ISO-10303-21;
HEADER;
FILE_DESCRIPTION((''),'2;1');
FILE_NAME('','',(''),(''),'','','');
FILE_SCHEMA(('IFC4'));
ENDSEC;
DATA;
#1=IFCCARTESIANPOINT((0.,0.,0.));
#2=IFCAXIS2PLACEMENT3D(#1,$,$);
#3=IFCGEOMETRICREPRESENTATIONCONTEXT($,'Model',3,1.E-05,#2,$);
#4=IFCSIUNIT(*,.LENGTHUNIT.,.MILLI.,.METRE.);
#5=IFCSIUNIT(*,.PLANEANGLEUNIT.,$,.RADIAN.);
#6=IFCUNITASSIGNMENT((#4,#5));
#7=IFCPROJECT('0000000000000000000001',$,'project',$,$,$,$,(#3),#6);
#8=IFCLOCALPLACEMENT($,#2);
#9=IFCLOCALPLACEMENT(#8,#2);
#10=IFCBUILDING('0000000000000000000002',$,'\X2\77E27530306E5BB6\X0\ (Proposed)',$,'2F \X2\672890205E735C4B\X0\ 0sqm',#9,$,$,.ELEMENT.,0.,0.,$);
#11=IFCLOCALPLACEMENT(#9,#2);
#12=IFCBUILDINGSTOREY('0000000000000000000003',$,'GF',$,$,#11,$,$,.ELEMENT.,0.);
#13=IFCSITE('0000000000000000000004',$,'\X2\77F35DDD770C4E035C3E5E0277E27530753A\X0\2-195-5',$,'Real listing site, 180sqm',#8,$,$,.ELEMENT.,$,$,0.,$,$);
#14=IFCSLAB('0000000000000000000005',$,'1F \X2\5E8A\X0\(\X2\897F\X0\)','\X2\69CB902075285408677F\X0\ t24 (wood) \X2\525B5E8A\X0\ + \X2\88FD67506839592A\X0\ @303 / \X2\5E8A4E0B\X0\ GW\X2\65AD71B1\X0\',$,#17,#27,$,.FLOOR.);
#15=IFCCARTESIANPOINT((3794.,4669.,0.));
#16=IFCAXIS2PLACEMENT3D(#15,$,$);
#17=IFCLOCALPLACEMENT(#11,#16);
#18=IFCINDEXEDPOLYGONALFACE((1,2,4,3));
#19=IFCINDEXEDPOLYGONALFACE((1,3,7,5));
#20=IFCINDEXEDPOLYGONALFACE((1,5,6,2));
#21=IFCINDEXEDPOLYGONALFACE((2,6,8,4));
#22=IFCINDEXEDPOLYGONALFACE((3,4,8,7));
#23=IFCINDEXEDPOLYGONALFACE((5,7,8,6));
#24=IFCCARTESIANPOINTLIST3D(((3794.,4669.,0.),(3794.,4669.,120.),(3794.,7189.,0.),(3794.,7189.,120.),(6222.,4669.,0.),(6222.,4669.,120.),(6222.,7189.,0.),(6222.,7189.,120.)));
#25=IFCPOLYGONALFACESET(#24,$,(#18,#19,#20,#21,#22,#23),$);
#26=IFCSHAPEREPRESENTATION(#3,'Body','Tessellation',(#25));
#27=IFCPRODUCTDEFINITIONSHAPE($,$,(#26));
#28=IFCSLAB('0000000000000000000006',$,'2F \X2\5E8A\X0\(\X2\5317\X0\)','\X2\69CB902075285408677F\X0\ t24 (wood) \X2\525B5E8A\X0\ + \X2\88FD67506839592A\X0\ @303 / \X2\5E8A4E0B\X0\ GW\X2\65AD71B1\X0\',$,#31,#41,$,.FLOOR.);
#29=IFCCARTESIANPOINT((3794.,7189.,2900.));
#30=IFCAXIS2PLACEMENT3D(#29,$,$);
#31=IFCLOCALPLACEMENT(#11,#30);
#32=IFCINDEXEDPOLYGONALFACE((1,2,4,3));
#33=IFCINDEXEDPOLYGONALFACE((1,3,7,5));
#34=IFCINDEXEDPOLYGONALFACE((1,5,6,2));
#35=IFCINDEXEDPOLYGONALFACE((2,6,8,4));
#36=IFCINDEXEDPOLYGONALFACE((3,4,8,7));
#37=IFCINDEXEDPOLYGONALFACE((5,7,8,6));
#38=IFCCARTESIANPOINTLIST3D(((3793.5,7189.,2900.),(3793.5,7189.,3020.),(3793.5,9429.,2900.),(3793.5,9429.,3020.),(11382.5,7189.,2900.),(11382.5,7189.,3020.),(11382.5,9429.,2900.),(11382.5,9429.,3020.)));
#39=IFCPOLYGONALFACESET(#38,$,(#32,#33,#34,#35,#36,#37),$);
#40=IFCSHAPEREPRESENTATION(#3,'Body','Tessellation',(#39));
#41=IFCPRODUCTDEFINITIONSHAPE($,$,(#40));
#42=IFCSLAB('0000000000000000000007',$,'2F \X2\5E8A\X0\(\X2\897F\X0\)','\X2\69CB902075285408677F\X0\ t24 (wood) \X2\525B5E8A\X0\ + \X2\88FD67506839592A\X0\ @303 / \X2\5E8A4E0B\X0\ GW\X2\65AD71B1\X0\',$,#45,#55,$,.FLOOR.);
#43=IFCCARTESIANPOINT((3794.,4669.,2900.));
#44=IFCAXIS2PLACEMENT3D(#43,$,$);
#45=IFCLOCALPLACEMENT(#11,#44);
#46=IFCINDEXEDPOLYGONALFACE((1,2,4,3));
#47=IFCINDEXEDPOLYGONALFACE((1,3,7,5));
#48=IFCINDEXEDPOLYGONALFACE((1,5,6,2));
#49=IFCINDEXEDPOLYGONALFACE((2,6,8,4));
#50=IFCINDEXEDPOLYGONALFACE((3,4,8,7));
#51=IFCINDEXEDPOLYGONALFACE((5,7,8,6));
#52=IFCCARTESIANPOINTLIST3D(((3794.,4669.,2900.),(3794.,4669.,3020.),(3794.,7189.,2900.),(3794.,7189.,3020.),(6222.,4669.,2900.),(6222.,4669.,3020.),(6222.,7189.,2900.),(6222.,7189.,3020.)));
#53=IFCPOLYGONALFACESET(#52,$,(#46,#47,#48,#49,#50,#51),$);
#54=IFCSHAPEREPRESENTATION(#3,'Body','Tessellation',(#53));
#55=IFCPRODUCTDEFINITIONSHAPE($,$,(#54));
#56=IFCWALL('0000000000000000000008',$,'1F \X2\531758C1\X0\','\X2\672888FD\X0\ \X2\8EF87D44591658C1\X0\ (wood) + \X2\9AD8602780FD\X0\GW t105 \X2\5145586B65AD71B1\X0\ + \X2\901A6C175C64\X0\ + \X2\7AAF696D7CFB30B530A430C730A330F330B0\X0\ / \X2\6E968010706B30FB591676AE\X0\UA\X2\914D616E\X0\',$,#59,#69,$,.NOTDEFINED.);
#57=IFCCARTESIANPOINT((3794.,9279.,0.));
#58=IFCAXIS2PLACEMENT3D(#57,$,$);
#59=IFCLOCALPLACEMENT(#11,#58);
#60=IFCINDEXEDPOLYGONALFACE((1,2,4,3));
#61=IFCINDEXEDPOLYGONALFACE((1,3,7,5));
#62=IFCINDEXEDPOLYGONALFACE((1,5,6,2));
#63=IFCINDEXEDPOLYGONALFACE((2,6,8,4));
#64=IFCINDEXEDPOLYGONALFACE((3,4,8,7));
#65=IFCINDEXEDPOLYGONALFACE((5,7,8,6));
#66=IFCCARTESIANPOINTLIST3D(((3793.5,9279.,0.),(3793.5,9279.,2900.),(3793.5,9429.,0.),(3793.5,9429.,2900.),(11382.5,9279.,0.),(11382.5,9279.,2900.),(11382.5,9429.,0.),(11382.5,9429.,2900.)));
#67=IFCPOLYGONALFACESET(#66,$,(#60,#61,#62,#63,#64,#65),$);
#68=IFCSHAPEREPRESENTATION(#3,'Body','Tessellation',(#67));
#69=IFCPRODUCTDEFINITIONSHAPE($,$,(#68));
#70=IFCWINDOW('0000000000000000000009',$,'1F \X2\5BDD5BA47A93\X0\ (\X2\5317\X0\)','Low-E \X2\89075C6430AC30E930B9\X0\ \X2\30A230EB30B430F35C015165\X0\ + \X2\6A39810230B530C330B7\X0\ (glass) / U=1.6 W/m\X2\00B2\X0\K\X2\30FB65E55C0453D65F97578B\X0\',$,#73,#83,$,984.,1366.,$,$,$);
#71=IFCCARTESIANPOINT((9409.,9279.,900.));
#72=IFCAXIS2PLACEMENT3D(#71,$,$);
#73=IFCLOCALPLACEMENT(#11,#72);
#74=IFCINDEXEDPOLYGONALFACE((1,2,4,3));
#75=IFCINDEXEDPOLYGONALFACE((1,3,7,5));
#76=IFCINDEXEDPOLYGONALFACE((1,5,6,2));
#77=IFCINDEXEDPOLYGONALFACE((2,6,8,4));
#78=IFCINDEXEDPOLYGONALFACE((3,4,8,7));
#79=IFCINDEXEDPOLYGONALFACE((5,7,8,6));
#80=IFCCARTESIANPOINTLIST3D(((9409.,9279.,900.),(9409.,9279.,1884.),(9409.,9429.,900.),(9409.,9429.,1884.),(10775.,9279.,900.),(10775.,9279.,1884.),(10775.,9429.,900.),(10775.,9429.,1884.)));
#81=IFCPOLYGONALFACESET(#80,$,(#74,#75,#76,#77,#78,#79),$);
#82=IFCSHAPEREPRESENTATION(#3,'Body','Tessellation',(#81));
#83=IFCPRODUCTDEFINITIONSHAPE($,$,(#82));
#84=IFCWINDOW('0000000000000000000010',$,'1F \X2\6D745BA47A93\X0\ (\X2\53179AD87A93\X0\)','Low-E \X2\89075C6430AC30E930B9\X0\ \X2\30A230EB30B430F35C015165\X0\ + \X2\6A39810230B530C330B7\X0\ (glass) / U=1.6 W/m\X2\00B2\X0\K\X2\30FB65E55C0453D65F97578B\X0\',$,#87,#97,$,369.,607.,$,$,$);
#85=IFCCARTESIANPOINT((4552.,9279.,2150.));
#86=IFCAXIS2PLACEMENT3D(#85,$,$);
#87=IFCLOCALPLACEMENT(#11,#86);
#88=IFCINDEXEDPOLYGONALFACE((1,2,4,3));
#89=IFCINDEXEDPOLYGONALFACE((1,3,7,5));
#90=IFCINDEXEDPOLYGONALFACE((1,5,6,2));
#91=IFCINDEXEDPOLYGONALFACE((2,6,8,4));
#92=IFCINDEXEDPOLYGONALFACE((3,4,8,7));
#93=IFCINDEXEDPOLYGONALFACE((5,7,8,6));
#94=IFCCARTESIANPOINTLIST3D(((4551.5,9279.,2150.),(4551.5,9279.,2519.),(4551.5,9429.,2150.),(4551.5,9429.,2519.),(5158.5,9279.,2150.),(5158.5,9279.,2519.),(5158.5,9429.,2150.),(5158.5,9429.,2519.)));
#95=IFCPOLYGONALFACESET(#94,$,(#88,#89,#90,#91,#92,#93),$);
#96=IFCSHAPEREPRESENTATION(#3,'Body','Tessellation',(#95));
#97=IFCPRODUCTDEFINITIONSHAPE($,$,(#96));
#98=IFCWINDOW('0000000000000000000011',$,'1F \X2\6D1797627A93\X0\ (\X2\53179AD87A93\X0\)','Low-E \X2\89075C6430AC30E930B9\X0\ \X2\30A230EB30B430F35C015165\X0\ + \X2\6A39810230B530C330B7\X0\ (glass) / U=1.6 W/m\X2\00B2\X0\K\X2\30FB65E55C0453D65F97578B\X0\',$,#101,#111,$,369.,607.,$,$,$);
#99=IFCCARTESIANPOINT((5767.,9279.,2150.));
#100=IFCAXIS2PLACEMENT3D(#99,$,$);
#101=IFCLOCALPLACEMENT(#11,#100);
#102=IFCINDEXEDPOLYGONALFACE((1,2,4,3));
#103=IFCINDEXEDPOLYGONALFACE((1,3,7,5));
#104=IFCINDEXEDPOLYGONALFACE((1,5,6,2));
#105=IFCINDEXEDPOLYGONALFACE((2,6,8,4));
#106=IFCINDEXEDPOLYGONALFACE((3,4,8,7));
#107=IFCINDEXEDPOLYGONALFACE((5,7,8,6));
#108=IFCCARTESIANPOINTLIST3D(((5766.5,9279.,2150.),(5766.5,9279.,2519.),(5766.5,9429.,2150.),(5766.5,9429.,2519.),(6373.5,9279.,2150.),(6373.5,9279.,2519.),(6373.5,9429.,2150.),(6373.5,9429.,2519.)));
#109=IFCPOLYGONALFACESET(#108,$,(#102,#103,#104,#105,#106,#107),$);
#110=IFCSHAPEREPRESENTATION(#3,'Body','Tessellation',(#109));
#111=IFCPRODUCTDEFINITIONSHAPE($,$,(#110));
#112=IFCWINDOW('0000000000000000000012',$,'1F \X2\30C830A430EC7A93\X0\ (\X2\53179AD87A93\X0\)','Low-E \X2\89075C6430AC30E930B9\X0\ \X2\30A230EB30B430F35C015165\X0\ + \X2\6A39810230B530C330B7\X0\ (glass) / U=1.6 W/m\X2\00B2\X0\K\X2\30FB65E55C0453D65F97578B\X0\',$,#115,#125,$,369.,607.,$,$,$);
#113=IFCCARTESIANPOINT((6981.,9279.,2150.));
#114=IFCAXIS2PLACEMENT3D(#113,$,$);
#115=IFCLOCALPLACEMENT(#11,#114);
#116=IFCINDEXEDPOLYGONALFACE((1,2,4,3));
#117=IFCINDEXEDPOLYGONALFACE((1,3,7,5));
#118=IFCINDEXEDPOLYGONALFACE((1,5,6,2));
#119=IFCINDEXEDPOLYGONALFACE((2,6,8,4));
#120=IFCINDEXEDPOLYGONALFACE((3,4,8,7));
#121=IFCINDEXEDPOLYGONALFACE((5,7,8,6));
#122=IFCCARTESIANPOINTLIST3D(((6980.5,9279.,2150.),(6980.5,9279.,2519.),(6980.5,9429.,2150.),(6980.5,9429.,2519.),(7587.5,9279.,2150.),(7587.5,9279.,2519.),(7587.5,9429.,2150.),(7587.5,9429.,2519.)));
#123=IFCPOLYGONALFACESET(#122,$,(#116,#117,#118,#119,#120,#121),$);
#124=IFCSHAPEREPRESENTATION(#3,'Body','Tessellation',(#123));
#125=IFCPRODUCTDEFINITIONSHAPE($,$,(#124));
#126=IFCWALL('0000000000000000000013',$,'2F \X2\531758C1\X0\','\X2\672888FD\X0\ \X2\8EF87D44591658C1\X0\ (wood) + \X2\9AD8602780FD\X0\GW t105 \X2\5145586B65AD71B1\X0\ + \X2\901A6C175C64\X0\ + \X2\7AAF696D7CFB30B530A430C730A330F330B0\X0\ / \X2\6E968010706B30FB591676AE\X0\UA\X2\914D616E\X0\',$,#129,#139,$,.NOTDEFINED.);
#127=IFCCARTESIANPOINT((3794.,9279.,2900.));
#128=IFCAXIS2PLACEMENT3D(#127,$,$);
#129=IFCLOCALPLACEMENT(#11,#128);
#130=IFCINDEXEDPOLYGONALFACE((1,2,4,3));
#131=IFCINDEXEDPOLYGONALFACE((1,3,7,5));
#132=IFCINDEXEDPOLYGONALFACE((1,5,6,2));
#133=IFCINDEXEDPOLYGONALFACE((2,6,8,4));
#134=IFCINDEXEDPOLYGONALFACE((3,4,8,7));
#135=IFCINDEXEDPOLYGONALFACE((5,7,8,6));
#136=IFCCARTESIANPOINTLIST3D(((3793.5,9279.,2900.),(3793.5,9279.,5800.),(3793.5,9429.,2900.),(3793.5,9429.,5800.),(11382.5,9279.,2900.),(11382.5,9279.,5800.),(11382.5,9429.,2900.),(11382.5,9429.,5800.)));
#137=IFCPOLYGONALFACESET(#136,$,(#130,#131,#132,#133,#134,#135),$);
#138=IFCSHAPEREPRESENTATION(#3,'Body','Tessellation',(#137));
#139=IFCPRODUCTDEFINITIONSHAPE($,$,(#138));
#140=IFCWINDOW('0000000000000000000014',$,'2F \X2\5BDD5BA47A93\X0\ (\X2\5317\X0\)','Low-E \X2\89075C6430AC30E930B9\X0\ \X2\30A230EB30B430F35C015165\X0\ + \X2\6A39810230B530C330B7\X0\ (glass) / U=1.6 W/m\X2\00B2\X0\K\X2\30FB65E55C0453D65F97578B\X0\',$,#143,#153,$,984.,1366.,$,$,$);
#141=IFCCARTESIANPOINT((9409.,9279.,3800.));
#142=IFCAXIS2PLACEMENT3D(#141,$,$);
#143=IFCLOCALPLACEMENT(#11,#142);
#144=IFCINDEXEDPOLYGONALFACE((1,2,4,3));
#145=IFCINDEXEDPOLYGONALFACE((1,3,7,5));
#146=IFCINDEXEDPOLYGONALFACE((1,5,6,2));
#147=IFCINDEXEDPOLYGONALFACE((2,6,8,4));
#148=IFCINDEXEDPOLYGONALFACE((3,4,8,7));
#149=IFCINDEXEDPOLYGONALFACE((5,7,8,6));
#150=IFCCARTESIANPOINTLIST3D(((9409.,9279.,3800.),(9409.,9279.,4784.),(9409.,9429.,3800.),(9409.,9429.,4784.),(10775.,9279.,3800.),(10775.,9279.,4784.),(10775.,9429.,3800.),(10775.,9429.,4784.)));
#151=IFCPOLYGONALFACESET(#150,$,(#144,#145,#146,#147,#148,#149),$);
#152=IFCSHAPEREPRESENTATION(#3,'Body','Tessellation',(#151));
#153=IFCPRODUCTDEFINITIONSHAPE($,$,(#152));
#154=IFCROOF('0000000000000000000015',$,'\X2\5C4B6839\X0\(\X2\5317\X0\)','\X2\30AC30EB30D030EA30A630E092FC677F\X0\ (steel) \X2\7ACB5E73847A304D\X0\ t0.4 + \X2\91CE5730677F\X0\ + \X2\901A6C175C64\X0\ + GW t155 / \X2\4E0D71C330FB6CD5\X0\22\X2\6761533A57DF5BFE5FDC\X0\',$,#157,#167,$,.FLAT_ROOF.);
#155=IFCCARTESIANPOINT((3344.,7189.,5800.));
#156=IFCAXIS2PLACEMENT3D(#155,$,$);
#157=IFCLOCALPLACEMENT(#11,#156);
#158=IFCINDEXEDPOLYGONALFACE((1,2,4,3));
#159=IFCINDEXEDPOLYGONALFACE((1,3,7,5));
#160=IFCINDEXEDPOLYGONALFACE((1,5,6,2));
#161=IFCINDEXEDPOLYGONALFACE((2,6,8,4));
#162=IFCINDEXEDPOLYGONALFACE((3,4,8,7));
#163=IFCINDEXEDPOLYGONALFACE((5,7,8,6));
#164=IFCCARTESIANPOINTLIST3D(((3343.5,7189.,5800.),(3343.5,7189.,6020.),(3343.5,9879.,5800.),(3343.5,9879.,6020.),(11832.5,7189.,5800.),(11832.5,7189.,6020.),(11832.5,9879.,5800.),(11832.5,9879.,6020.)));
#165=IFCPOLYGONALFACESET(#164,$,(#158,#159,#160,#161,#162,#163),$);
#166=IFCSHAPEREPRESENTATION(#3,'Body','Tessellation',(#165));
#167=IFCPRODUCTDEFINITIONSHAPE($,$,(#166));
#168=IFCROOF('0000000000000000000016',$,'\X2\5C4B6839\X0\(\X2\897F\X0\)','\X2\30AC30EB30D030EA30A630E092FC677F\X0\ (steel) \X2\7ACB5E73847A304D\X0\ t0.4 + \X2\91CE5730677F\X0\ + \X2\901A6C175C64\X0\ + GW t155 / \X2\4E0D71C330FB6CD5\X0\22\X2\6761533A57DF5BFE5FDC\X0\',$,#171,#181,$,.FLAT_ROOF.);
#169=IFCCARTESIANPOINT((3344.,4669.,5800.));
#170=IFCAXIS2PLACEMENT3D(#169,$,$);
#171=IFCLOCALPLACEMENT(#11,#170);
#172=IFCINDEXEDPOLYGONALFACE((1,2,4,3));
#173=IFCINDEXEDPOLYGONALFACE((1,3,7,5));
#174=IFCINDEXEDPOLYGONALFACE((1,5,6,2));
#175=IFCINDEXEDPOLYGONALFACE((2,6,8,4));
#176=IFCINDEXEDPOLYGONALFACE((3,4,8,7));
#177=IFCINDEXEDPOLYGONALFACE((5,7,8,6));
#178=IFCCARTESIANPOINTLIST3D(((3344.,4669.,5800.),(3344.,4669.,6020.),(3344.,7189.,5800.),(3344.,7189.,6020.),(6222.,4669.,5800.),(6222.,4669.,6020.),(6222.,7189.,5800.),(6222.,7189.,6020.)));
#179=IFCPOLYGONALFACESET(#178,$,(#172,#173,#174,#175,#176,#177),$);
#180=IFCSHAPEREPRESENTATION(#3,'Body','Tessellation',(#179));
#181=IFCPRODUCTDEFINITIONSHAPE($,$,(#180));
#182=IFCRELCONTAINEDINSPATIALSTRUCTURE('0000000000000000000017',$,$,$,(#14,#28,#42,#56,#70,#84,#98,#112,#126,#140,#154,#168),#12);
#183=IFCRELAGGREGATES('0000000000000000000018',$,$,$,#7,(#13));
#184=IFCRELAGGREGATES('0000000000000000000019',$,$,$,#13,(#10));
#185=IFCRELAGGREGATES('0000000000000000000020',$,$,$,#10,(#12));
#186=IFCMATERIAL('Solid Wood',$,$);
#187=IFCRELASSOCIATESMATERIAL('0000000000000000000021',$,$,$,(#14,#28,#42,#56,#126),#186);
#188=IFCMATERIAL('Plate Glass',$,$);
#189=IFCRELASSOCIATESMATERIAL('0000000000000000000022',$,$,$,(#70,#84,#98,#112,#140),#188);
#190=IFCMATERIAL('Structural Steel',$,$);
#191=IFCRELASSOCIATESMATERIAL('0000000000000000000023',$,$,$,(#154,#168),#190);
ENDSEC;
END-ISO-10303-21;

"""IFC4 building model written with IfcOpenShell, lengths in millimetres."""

from ifc_helpers import new_model, si_unit, frame, frame_2d, origin, place, context, project, spatial, rectangle, extrude, material, element, fill, save


model = new_model("IFC4")

# Units and contexts
model_context = context("Model", 3, precision=1e-05, world=origin())
ifc_project = project(units=[si_unit("LENGTHUNIT", "METRE", prefix="MILLI"), si_unit("PLANEANGLEUNIT", "RADIAN")], contexts=[model_context])

# Site, building, storey
site_placement = place(None, origin())
site = spatial("IfcSite", under=ifc_project, at=site_placement, Name="石川県七尾市矢田町2-195-5", ObjectType="Real listing site, 180sqm", CompositionType="ELEMENT", RefElevation=0.0)
building_placement = place(site_placement, origin())
building = spatial("IfcBuilding", under=site, at=building_placement, Name="矢田の家 (Proposed)", ObjectType="2F 木造平屋 0sqm", CompositionType="ELEMENT", ElevationOfRefHeight=0.0, ElevationOfTerrain=0.0)
storey_placement = place(building_placement, origin())
storey = spatial("IfcBuildingStorey", under=building, at=storey_placement, Name="GF", CompositionType="ELEMENT", Elevation=0.0)

# Slabs
ifc_material_1 = material(Name="Solid Wood")
slab_1_placement = place(storey_placement, frame((3794.0, 4669.0, 0.0)))
element("IfcSlab", 1, at=slab_1_placement, inside=storey, material=ifc_material_1, Name="1F 床(西)", Description="構造用合板 t24 (wood) 剛床 + 製材根太 @303 / 床下 GW断熱", PredefinedType="FLOOR", context=model_context, shape_type="SweptSolid", body=[
    extrude(rectangle(XDim=2428.0, YDim=2520.0, at=frame_2d((1214.0, 1260.0))), frame((3794.0, 4669.0, 0.0)), (0.0, 0.0, 1.0), 120.0),
])
slab_2_placement = place(storey_placement, frame((3794.0, 7189.0, 2900.0)))
element("IfcSlab", 2, at=slab_2_placement, inside=storey, material=ifc_material_1, Name="2F 床(北)", Description="構造用合板 t24 (wood) 剛床 + 製材根太 @303 / 床下 GW断熱", PredefinedType="FLOOR", context=model_context, shape_type="SweptSolid", body=[
    extrude(rectangle(XDim=7589.0, YDim=2240.0, at=frame_2d((3794.0, 1120.0))), frame((3794.0, 7189.0, 2900.0)), (0.0, 0.0, 1.0), 120.0),
])
slab_3_placement = place(storey_placement, frame((3794.0, 4669.0, 2900.0)))
element("IfcSlab", 3, at=slab_3_placement, inside=storey, material=ifc_material_1, Name="2F 床(西)", Description="構造用合板 t24 (wood) 剛床 + 製材根太 @303 / 床下 GW断熱", PredefinedType="FLOOR", context=model_context, shape_type="SweptSolid", body=[
    extrude(rectangle(XDim=2428.0, YDim=2520.0, at=frame_2d((1214.0, 1260.0))), frame((3794.0, 4669.0, 2900.0)), (0.0, 0.0, 1.0), 120.0),
])

# Wall, openings, windows
wall_1_placement = place(storey_placement, frame((3794.0, 9279.0, 0.0)))
wall_1 = element("IfcWall", 4, at=wall_1_placement, inside=storey, material=ifc_material_1, Name="1F 北壁", Description="木製 軸組外壁 (wood) + 高性能GW t105 充填断熱 + 通気層 + 窯業系サイディング / 準耐火・外皮UA配慮", PredefinedType="NOTDEFINED", context=model_context, shape_type="SweptSolid", body=[
    extrude(rectangle(XDim=7589.0, YDim=150.0, at=frame_2d((3794.0, 75.0))), frame((3794.0, 9279.0, 0.0)), (0.0, 0.0, 1.0), 2900.0),
])
opening_1_placement = place(storey_placement, frame((9409.0, 9279.0, 900.0)))
opening_1 = element("IfcOpeningElement", 5, at=opening_1_placement, cuts=wall_1, PredefinedType="NOTDEFINED", context=model_context, shape_type="SweptSolid", body=[
    extrude(rectangle(XDim=1366.0, YDim=150.0, at=frame_2d((683.0, 75.0))), frame((9409.0, 9279.0, 900.0)), (0.0, 0.0, 1.0), 984.0),
])
opening_2_placement = place(storey_placement, frame((4552.0, 9279.0, 2150.0)))
opening_2 = element("IfcOpeningElement", 6, at=opening_2_placement, cuts=wall_1, PredefinedType="NOTDEFINED", context=model_context, shape_type="SweptSolid", body=[
    extrude(rectangle(XDim=607.0, YDim=150.0, at=frame_2d((303.0, 75.0))), frame((4552.0, 9279.0, 2150.0)), (0.0, 0.0, 1.0), 369.0),
])
opening_3_placement = place(storey_placement, frame((5767.0, 9279.0, 2150.0)))
opening_3 = element("IfcOpeningElement", 7, at=opening_3_placement, cuts=wall_1, PredefinedType="NOTDEFINED", context=model_context, shape_type="SweptSolid", body=[
    extrude(rectangle(XDim=607.0, YDim=150.0, at=frame_2d((303.0, 75.0))), frame((5767.0, 9279.0, 2150.0)), (0.0, 0.0, 1.0), 369.0),
])
opening_4_placement = place(storey_placement, frame((6981.0, 9279.0, 2150.0)))
opening_4 = element("IfcOpeningElement", 8, at=opening_4_placement, cuts=wall_1, PredefinedType="NOTDEFINED", context=model_context, shape_type="SweptSolid", body=[
    extrude(rectangle(XDim=607.0, YDim=150.0, at=frame_2d((303.0, 75.0))), frame((6981.0, 9279.0, 2150.0)), (0.0, 0.0, 1.0), 369.0),
])
ifc_material_2 = material(Name="Plate Glass")
window_1_placement = place(storey_placement, frame((9409.0, 9279.0, 900.0)))
window_1 = element("IfcWindow", 9, at=window_1_placement, inside=storey, material=ifc_material_2, Name="1F 寝室窓 (北)", Description="Low-E 複層ガラス アルゴン封入 + 樹脂サッシ (glass) / U=1.6 W/m²K・日射取得型", OverallHeight=984.0, OverallWidth=1366.0, context=model_context, shape_type="SweptSolid", body=[
    extrude(rectangle(XDim=1366.0, YDim=150.0, at=frame_2d((683.0, 75.0))), frame((9409.0, 9279.0, 900.0)), (0.0, 0.0, 1.0), 984.0),
])
fill(opening_1, window_1)
window_2_placement = place(storey_placement, frame((4552.0, 9279.0, 2150.0)))
window_2 = element("IfcWindow", 10, at=window_2_placement, inside=storey, material=ifc_material_2, Name="1F 浴室窓 (北高窓)", Description="Low-E 複層ガラス アルゴン封入 + 樹脂サッシ (glass) / U=1.6 W/m²K・日射取得型", OverallHeight=369.0, OverallWidth=607.0, context=model_context, shape_type="SweptSolid", body=[
    extrude(rectangle(XDim=607.0, YDim=150.0, at=frame_2d((303.0, 75.0))), frame((4552.0, 9279.0, 2150.0)), (0.0, 0.0, 1.0), 369.0),
])
fill(opening_2, window_2)
window_3_placement = place(storey_placement, frame((5767.0, 9279.0, 2150.0)))
window_3 = element("IfcWindow", 11, at=window_3_placement, inside=storey, material=ifc_material_2, Name="1F 洗面窓 (北高窓)", Description="Low-E 複層ガラス アルゴン封入 + 樹脂サッシ (glass) / U=1.6 W/m²K・日射取得型", OverallHeight=369.0, OverallWidth=607.0, context=model_context, shape_type="SweptSolid", body=[
    extrude(rectangle(XDim=607.0, YDim=150.0, at=frame_2d((303.0, 75.0))), frame((5767.0, 9279.0, 2150.0)), (0.0, 0.0, 1.0), 369.0),
])
fill(opening_3, window_3)
window_4_placement = place(storey_placement, frame((6981.0, 9279.0, 2150.0)))
window_4 = element("IfcWindow", 12, at=window_4_placement, inside=storey, material=ifc_material_2, Name="1F トイレ窓 (北高窓)", Description="Low-E 複層ガラス アルゴン封入 + 樹脂サッシ (glass) / U=1.6 W/m²K・日射取得型", OverallHeight=369.0, OverallWidth=607.0, context=model_context, shape_type="SweptSolid", body=[
    extrude(rectangle(XDim=607.0, YDim=150.0, at=frame_2d((303.0, 75.0))), frame((6981.0, 9279.0, 2150.0)), (0.0, 0.0, 1.0), 369.0),
])
fill(opening_4, window_4)

# Wall, opening, window
wall_2_placement = place(storey_placement, frame((3794.0, 9279.0, 2900.0)))
wall_2 = element("IfcWall", 13, at=wall_2_placement, inside=storey, material=ifc_material_1, Name="2F 北壁", Description="木製 軸組外壁 (wood) + 高性能GW t105 充填断熱 + 通気層 + 窯業系サイディング / 準耐火・外皮UA配慮", PredefinedType="NOTDEFINED", context=model_context, shape_type="SweptSolid", body=[
    extrude(rectangle(XDim=7589.0, YDim=150.0, at=frame_2d((3794.0, 75.0))), frame((3794.0, 9279.0, 2900.0)), (0.0, 0.0, 1.0), 2900.0),
])
opening_5_placement = place(storey_placement, frame((9409.0, 9279.0, 3800.0)))
opening_5 = element("IfcOpeningElement", 14, at=opening_5_placement, cuts=wall_2, PredefinedType="NOTDEFINED", context=model_context, shape_type="SweptSolid", body=[
    extrude(rectangle(XDim=1366.0, YDim=150.0, at=frame_2d((683.0, 75.0))), frame((9409.0, 9279.0, 3800.0)), (0.0, 0.0, 1.0), 984.0),
])
window_5_placement = place(storey_placement, frame((9409.0, 9279.0, 3800.0)))
window_5 = element("IfcWindow", 15, at=window_5_placement, inside=storey, material=ifc_material_2, Name="2F 寝室窓 (北)", Description="Low-E 複層ガラス アルゴン封入 + 樹脂サッシ (glass) / U=1.6 W/m²K・日射取得型", OverallHeight=984.0, OverallWidth=1366.0, context=model_context, shape_type="SweptSolid", body=[
    extrude(rectangle(XDim=1366.0, YDim=150.0, at=frame_2d((683.0, 75.0))), frame((9409.0, 9279.0, 3800.0)), (0.0, 0.0, 1.0), 984.0),
])
fill(opening_5, window_5)

# Roofs
ifc_material_3 = material(Name="Structural Steel")
for number, where, name in (
    (16, (3344.0, 7189.0, 5800.0), "屋根(北)"),
):
    element("IfcRoof", number, at=place(storey_placement, frame(where)), inside=storey, material=ifc_material_3, Name=name, Description="ガルバリウム鋼板 (steel) 立平葺き t0.4 + 野地板 + 通気層 + GW t155 / 不燃・法22条区域対応", PredefinedType="FLAT_ROOF", context=model_context, shape_type="SweptSolid", body=[
        extrude(rectangle(XDim=8489.0, YDim=2690.0, at=frame_2d((4244.0, 1345.0))), frame((3344.0, 7189.0, 5800.0)), (0.0, 0.0, 1.0), 220.0),
    ])
roof_placement = place(storey_placement, frame((3344.0, 4669.0, 5800.0)))
element("IfcRoof", 17, at=roof_placement, inside=storey, material=ifc_material_3, Name="屋根(西)", Description="ガルバリウム鋼板 (steel) 立平葺き t0.4 + 野地板 + 通気層 + GW t155 / 不燃・法22条区域対応", PredefinedType="FLAT_ROOF", context=model_context, shape_type="SweptSolid", body=[
    extrude(rectangle(XDim=2878.0, YDim=2520.0, at=frame_2d((1439.0, 1260.0))), frame((3344.0, 4669.0, 5800.0)), (0.0, 0.0, 1.0), 220.0),
])

save(model, "model.ifc")
